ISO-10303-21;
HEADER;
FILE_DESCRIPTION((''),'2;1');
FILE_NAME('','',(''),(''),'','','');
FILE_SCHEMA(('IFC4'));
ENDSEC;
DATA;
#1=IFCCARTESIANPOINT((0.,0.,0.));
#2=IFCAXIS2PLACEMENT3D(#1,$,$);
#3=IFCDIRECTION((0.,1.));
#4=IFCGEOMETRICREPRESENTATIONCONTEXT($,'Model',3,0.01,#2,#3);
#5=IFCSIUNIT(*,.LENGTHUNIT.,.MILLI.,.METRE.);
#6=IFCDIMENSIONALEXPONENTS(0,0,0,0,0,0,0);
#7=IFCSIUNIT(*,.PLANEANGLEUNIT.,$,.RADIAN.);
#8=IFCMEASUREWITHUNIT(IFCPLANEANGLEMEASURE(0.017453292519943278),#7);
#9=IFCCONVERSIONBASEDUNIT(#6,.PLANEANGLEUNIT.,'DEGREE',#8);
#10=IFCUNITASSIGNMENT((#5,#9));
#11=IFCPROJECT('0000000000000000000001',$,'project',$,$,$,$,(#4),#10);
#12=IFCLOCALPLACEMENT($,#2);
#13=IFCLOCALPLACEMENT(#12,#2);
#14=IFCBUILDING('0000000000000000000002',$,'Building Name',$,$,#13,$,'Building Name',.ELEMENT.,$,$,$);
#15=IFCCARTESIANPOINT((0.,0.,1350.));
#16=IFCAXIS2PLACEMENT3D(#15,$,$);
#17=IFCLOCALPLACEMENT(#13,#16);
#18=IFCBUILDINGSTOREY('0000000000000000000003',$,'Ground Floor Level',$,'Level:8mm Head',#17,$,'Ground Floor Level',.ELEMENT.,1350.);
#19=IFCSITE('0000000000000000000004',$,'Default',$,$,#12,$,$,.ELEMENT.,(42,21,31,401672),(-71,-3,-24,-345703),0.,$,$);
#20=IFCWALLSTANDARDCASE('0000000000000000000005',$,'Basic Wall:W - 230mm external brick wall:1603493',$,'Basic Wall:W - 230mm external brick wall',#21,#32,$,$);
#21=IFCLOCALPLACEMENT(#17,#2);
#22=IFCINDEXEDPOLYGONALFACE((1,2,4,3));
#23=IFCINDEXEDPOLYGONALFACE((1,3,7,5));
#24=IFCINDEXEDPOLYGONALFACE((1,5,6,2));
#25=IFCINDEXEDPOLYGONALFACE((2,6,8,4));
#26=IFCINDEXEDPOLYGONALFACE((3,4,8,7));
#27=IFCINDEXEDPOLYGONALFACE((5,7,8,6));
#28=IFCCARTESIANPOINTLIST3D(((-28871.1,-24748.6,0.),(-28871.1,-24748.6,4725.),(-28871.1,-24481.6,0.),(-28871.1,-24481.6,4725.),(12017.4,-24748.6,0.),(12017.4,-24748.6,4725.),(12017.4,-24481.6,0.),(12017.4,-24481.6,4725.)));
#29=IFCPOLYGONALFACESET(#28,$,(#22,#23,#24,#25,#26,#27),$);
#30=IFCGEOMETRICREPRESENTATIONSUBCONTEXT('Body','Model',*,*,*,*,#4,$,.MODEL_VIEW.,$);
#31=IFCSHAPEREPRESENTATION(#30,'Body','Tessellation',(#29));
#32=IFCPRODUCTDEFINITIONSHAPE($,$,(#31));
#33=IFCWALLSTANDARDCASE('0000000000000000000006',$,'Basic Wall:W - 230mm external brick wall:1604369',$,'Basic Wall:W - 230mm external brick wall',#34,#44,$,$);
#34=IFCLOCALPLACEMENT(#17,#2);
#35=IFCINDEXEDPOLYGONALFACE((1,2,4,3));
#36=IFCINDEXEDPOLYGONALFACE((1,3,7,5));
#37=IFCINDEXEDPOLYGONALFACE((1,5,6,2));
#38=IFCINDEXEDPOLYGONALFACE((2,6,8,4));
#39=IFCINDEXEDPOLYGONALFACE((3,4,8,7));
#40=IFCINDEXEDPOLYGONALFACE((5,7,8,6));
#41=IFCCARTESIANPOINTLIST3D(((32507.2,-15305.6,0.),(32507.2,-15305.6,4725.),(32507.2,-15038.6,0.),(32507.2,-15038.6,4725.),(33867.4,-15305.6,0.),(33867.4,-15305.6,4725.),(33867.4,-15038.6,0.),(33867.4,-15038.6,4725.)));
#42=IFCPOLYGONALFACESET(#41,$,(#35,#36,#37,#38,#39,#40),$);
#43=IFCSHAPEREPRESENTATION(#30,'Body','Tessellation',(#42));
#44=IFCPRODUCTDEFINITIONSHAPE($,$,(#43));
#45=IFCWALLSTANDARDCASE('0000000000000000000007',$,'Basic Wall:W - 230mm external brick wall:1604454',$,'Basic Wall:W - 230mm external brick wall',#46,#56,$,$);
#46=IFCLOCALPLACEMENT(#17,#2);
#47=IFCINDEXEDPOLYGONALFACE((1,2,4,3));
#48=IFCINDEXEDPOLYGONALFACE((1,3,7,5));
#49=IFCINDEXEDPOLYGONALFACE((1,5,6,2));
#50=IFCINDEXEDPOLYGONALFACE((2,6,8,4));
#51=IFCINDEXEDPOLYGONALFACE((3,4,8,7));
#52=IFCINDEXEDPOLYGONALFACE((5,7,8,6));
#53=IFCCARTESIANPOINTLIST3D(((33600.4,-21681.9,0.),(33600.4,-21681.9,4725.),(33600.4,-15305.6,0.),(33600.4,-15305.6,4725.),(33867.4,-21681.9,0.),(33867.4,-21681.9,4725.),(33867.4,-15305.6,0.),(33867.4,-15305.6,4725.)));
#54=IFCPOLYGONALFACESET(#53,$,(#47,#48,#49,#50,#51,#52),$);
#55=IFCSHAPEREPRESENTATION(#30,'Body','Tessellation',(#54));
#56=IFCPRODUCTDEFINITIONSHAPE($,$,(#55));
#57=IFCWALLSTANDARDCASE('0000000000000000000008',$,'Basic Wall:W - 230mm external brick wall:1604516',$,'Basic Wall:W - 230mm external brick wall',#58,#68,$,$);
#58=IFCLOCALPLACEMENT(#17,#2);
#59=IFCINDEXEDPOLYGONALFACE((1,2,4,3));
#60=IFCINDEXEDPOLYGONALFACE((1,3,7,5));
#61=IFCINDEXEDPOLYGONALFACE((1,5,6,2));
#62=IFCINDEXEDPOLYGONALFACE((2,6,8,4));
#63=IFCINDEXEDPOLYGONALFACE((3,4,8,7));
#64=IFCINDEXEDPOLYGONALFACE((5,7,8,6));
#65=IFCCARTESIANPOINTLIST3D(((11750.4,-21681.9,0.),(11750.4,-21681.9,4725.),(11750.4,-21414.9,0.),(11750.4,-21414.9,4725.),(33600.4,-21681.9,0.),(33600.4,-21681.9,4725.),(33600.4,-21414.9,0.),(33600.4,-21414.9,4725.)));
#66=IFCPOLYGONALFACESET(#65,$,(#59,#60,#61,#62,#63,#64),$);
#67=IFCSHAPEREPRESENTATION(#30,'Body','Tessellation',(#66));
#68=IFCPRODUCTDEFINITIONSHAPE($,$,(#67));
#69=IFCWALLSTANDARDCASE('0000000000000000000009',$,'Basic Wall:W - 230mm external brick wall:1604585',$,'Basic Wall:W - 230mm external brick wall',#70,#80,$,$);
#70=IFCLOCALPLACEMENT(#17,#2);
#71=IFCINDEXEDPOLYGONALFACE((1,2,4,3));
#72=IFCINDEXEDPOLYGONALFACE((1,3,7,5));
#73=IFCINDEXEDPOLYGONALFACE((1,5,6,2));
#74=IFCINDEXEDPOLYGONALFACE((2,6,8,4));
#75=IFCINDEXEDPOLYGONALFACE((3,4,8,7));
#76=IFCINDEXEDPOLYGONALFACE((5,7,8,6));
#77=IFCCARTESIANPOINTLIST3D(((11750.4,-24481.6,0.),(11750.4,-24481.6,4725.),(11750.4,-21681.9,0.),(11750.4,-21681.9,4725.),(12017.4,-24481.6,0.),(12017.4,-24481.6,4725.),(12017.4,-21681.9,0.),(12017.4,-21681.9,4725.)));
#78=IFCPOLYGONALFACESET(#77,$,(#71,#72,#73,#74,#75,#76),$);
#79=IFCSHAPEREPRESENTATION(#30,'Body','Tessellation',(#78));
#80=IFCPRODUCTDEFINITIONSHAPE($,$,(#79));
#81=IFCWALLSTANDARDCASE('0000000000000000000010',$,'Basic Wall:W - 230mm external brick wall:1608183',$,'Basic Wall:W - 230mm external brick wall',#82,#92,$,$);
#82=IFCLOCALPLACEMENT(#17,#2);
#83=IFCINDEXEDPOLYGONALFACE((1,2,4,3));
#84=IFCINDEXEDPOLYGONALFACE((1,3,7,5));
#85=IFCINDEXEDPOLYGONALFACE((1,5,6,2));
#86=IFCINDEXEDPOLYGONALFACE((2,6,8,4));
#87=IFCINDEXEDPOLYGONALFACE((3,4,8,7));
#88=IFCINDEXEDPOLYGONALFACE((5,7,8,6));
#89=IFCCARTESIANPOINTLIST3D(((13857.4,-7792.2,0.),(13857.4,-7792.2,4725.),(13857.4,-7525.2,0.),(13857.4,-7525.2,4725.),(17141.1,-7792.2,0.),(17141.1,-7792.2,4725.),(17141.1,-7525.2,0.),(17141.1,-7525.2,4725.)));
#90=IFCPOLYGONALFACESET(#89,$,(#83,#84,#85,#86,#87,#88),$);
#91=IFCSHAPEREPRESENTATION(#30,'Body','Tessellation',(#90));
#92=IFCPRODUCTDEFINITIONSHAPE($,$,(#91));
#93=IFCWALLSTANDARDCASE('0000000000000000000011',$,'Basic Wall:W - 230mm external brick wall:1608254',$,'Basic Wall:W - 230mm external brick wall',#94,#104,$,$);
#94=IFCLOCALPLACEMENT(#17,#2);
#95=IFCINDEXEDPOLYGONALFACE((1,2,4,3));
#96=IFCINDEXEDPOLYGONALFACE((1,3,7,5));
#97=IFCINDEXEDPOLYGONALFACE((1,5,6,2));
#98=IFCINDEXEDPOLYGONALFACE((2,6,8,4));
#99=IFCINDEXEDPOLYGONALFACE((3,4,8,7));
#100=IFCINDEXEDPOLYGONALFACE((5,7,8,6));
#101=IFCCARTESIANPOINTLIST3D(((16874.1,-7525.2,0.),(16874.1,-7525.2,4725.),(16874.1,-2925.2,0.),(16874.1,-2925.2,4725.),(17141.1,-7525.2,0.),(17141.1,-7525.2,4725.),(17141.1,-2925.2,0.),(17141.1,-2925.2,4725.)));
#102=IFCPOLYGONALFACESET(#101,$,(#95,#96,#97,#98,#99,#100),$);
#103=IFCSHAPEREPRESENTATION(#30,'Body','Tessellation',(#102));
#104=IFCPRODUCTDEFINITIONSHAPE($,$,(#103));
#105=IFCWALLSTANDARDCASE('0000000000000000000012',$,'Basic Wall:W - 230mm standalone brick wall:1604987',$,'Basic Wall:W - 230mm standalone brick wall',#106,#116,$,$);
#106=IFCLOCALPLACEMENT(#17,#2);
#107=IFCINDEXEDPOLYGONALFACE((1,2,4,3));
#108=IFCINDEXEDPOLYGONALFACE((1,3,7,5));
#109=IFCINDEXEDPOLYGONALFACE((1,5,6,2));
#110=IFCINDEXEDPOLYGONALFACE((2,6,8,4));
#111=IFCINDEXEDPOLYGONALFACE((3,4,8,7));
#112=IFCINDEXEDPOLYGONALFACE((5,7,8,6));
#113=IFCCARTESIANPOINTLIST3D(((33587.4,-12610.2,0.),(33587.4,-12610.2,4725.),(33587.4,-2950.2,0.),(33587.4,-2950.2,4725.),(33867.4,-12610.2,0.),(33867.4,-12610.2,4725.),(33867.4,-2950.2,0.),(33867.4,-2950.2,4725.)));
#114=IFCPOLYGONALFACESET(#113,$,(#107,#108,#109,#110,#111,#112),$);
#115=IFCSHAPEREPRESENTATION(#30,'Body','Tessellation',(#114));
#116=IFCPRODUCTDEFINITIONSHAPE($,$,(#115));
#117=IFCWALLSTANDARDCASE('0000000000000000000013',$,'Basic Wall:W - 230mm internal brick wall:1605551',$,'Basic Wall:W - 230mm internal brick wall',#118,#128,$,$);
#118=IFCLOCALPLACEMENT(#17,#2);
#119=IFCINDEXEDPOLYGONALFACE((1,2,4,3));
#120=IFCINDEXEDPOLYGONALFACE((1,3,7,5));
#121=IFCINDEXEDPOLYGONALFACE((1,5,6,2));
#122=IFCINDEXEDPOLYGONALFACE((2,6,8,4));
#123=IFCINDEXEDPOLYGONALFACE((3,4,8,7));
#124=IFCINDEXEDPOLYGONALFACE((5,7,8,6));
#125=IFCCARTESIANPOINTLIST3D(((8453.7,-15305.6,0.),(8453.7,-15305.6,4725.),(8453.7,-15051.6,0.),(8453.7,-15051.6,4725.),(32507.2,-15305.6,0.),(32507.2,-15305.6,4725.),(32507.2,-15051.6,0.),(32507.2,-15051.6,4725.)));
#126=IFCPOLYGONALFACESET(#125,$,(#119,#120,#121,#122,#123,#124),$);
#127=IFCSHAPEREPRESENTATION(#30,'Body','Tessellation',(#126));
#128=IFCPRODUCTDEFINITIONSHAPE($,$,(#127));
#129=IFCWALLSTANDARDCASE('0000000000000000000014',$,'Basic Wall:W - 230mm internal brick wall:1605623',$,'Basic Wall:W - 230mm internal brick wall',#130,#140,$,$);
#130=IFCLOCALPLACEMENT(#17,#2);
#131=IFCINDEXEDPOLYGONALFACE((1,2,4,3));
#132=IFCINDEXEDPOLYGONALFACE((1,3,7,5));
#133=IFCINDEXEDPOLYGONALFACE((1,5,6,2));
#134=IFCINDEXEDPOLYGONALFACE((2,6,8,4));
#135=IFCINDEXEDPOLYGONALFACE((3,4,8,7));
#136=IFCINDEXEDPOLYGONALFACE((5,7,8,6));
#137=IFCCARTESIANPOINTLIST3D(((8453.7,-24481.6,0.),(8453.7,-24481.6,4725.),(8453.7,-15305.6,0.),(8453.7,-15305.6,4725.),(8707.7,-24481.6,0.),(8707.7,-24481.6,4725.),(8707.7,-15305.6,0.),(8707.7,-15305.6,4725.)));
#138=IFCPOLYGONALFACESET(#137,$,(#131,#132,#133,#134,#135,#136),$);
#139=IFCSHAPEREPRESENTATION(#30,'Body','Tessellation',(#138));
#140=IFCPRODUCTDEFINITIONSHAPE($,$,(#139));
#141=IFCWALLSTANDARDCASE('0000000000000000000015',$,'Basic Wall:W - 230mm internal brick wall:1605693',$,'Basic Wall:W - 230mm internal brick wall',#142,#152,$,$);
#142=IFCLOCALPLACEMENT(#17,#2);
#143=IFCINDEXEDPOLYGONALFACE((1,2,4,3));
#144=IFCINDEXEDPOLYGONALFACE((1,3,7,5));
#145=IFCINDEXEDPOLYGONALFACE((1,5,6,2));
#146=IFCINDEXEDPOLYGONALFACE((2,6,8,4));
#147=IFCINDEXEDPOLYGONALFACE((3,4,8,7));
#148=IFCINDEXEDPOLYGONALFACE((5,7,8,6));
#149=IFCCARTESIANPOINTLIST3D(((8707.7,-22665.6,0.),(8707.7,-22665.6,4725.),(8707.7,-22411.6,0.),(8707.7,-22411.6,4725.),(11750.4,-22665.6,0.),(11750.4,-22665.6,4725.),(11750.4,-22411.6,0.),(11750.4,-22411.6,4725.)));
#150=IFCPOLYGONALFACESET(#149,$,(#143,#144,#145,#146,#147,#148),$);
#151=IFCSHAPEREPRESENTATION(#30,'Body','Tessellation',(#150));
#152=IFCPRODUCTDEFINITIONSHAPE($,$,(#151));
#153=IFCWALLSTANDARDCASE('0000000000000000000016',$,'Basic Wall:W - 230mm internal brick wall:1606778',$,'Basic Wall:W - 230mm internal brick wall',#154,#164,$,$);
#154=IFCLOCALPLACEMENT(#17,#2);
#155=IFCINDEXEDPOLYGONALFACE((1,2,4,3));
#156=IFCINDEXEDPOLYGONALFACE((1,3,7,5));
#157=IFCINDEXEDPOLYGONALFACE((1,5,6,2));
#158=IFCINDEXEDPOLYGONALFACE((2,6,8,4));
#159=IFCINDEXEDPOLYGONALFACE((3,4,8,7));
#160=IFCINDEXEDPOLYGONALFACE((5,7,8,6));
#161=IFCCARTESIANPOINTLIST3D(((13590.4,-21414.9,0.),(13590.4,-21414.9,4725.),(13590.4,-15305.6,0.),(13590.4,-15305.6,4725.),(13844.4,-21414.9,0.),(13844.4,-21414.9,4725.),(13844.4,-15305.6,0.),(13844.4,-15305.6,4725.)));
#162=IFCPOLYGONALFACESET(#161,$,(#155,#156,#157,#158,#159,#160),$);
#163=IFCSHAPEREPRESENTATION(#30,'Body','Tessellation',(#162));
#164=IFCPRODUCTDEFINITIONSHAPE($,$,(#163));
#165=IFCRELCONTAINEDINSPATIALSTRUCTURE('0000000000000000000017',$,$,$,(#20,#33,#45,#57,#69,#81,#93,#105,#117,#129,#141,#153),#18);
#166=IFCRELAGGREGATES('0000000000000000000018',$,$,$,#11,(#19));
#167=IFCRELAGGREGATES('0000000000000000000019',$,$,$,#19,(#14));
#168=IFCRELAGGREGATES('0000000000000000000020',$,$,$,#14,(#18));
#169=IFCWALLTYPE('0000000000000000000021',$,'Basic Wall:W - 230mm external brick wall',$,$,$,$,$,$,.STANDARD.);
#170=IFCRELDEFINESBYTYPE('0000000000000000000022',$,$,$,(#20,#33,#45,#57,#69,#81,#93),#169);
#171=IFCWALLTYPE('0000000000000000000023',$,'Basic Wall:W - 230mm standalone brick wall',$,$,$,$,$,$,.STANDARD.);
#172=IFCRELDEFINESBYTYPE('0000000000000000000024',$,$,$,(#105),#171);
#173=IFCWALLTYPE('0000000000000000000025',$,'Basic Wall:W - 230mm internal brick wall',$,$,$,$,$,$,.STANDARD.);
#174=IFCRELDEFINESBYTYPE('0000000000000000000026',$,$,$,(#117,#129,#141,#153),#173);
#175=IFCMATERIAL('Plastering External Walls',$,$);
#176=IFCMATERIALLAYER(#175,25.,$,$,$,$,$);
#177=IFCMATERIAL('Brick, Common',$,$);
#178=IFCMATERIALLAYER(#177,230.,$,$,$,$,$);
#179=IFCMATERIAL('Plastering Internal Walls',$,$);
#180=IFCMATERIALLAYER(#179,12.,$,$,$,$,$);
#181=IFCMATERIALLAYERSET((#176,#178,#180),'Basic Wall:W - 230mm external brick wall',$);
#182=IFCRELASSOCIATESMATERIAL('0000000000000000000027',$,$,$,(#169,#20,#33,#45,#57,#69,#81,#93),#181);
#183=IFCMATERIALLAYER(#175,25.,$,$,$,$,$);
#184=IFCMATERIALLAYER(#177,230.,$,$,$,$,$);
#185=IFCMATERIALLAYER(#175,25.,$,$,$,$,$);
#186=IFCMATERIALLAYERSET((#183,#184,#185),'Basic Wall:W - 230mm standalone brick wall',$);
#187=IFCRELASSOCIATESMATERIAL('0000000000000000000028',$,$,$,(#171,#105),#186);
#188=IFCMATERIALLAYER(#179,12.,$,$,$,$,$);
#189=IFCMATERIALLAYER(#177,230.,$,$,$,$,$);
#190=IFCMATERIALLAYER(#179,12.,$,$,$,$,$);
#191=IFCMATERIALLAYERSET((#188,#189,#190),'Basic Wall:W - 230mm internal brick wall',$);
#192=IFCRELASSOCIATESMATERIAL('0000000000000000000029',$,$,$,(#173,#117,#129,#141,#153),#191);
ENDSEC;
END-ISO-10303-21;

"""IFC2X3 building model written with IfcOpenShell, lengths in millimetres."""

from ifc_helpers import new_model, entity, si_unit, converted_unit, direction, frame, frame_2d, origin, place, context, subcontext, project, spatial, rectangle, extrude, material, layer, layer_set, layer_usage, type_object, element, save


model = new_model("IFC2X3")

# Units and contexts
model_context = context("Model", 3, precision=0.01, world=origin(), true_north=direction((0.0, 1.0)))
body_context = subcontext(model_context, "Body", "Model", "MODEL_VIEW")
ifc_project = project(units=[si_unit("LENGTHUNIT", "METRE", prefix="MILLI"), converted_unit("PLANEANGLEUNIT", "DEGREE", entity("IfcPlaneAngleMeasure", 0.017453292519943278), si_unit("PLANEANGLEUNIT", "RADIAN"), dimensions=[0, 0, 0, 0, 0, 0, 0])], contexts=[model_context])

# Site, building, storey
site_placement = place(None, origin())
site = spatial("IfcSite", under=ifc_project, at=site_placement, Name="Default", CompositionType="ELEMENT", RefLatitude=(42, 21, 31, 401672), RefLongitude=(-71, -3, -24, -345703), RefElevation=0.0)
building_placement = place(site_placement, origin())
building = spatial("IfcBuilding", under=site, at=building_placement, Name="Building Name", LongName="Building Name", CompositionType="ELEMENT")
storey_placement = place(building_placement, frame((0.0, 0.0, 1350.0)))
storey = spatial("IfcBuildingStorey", under=building, at=storey_placement, Name="Ground Floor Level", ObjectType="Level:8mm Head", LongName="Ground Floor Level", CompositionType="ELEMENT", Elevation=1350.0)

# Walls
ifc_material_1 = material(Name="Plastering External Walls")
ifc_layer_1 = layer(ifc_material_1, 25.0)
ifc_material_2 = material(Name="Brick, Common")
ifc_layer_2 = layer(ifc_material_2, 230.0)
ifc_material_3 = material(Name="Plastering Internal Walls")
ifc_layer_3 = layer(ifc_material_3, 12.0)
ifc_layer_set_1 = layer_set([ifc_layer_1, ifc_layer_2, ifc_layer_3], Name="Basic Wall:W - 230mm external brick wall")
ifc_layer_usage_1 = layer_usage(ifc_layer_set_1, "AXIS2", "NEGATIVE", 133.5)
wall_type_1 = type_object("IfcWallType", Name="Basic Wall:W - 230mm external brick wall", PredefinedType="STANDARD", material=ifc_layer_set_1)
wall_1_placement = place(storey_placement, frame((12017.4, -24615.1, 0.0), z_axis=(0.0, 0.0, 1.0), x_axis=(-1.0, 0.0, 0.0)))
element("IfcWallStandardCase", 1, at=wall_1_placement, inside=storey, type_object=wall_type_1, material=ifc_layer_usage_1, Name="Basic Wall:W - 230mm external brick wall:1603493", ObjectType="Basic Wall:W - 230mm external brick wall", context=body_context, shape_type="SweptSolid", body=[
    extrude(rectangle(XDim=40888.5, YDim=267.0, at=frame_2d((20444.2, 0.0), x_axis=(-1.0, 0.0))), origin(), (0.0, 0.0, 1.0), 4725.0),
])
ifc_layer_usage_2 = layer_usage(ifc_layer_set_1, "AXIS2", "NEGATIVE", 133.5)
wall_2_placement = place(storey_placement, frame((32507.2, -15172.1, 0.0)))
element("IfcWallStandardCase", 2, at=wall_2_placement, inside=storey, type_object=wall_type_1, material=ifc_layer_usage_2, Name="Basic Wall:W - 230mm external brick wall:1604369", ObjectType="Basic Wall:W - 230mm external brick wall", context=body_context, shape_type="SweptSolid", body=[
    extrude(rectangle(XDim=1360.2, YDim=267.0, at=frame_2d((680.1, 0.0), x_axis=(-1.0, 0.0))), origin(), (0.0, 0.0, 1.0), 4725.0),
])
ifc_layer_usage_3 = layer_usage(ifc_layer_set_1, "AXIS2", "NEGATIVE", 133.5)
wall_3_placement = place(storey_placement, frame((33733.9, -15305.6, 0.0), z_axis=(0.0, 0.0, 1.0), x_axis=(0.0, -1.0, 0.0)))
element("IfcWallStandardCase", 3, at=wall_3_placement, inside=storey, type_object=wall_type_1, material=ifc_layer_usage_3, Name="Basic Wall:W - 230mm external brick wall:1604454", ObjectType="Basic Wall:W - 230mm external brick wall", context=body_context, shape_type="SweptSolid", body=[
    extrude(rectangle(XDim=6376.3, YDim=267.0, at=frame_2d((3188.2, 0.0), x_axis=(-1.0, 0.0))), origin(), (0.0, 0.0, 1.0), 4725.0),
])
ifc_layer_usage_4 = layer_usage(ifc_layer_set_1, "AXIS2", "NEGATIVE", 133.5)
wall_4_placement = place(storey_placement, frame((33600.4, -21548.4, 0.0), z_axis=(0.0, 0.0, 1.0), x_axis=(-1.0, 0.0, 0.0)))
element("IfcWallStandardCase", 4, at=wall_4_placement, inside=storey, type_object=wall_type_1, material=ifc_layer_usage_4, Name="Basic Wall:W - 230mm external brick wall:1604516", ObjectType="Basic Wall:W - 230mm external brick wall", context=body_context, shape_type="SweptSolid", body=[
    extrude(rectangle(XDim=21850.0, YDim=267.0, at=frame_2d((10925.0, 0.0), x_axis=(-1.0, 0.0))), origin(), (0.0, 0.0, 1.0), 4725.0),
])
ifc_layer_usage_5 = layer_usage(ifc_layer_set_1, "AXIS2", "NEGATIVE", 133.5)
wall_5_placement = place(storey_placement, frame((11883.9, -21681.9, 0.0), z_axis=(0.0, 0.0, 1.0), x_axis=(0.0, -1.0, 0.0)))
element("IfcWallStandardCase", 5, at=wall_5_placement, inside=storey, type_object=wall_type_1, material=ifc_layer_usage_5, Name="Basic Wall:W - 230mm external brick wall:1604585", ObjectType="Basic Wall:W - 230mm external brick wall", context=body_context, shape_type="SweptSolid", body=[
    extrude(rectangle(XDim=2799.7, YDim=267.0, at=frame_2d((1399.8, 0.0), x_axis=(-1.0, 0.0))), origin(), (0.0, 0.0, 1.0), 4725.0),
])
ifc_layer_usage_6 = layer_usage(ifc_layer_set_1, "AXIS2", "NEGATIVE", 133.5)
wall_6_placement = place(storey_placement, frame((13857.4, -7658.7, 0.0)))
element("IfcWallStandardCase", 6, at=wall_6_placement, inside=storey, type_object=wall_type_1, material=ifc_layer_usage_6, Name="Basic Wall:W - 230mm external brick wall:1608183", ObjectType="Basic Wall:W - 230mm external brick wall", context=body_context, shape_type="SweptSolid", body=[
    extrude(rectangle(XDim=3283.7, YDim=267.0, at=frame_2d((1641.8, 0.0), x_axis=(-1.0, 0.0))), origin(), (0.0, 0.0, 1.0), 4725.0),
])
ifc_layer_usage_7 = layer_usage(ifc_layer_set_1, "AXIS2", "NEGATIVE", 133.5)
wall_7_placement = place(storey_placement, frame((17007.6, -7525.2, 0.0), z_axis=(0.0, 0.0, 1.0), x_axis=(0.0, 1.0, 0.0)))
element("IfcWallStandardCase", 7, at=wall_7_placement, inside=storey, type_object=wall_type_1, material=ifc_layer_usage_7, Name="Basic Wall:W - 230mm external brick wall:1608254", ObjectType="Basic Wall:W - 230mm external brick wall", context=body_context, shape_type="SweptSolid", body=[
    extrude(rectangle(XDim=4600.0, YDim=267.0, at=frame_2d((2300.0, 0.0), x_axis=(-1.0, 0.0))), origin(), (0.0, 0.0, 1.0), 4725.0),
])
ifc_layer_4 = layer(ifc_material_1, 25.0)
ifc_layer_5 = layer(ifc_material_2, 230.0)
ifc_layer_6 = layer(ifc_material_1, 25.0)
ifc_layer_set_2 = layer_set([ifc_layer_4, ifc_layer_5, ifc_layer_6], Name="Basic Wall:W - 230mm standalone brick wall")
ifc_layer_usage_8 = layer_usage(ifc_layer_set_2, "AXIS2", "NEGATIVE", 140.0)
wall_type_2 = type_object("IfcWallType", Name="Basic Wall:W - 230mm standalone brick wall", PredefinedType="STANDARD", material=ifc_layer_set_2)
wall_8_placement = place(storey_placement, frame((33727.4, -12610.2, 0.0), z_axis=(0.0, 0.0, 1.0), x_axis=(0.0, 1.0, 0.0)))
element("IfcWallStandardCase", 8, at=wall_8_placement, inside=storey, type_object=wall_type_2, material=ifc_layer_usage_8, Name="Basic Wall:W - 230mm standalone brick wall:1604987", ObjectType="Basic Wall:W - 230mm standalone brick wall", context=body_context, shape_type="SweptSolid", body=[
    extrude(rectangle(XDim=9660.0, YDim=280.0, at=frame_2d((4830.0, 0.0), x_axis=(-1.0, 0.0))), origin(), (0.0, 0.0, 1.0), 4725.0),
])
ifc_layer_7 = layer(ifc_material_3, 12.0)
ifc_layer_8 = layer(ifc_material_2, 230.0)
ifc_layer_9 = layer(ifc_material_3, 12.0)
ifc_layer_set_3 = layer_set([ifc_layer_7, ifc_layer_8, ifc_layer_9], Name="Basic Wall:W - 230mm internal brick wall")
ifc_layer_usage_9 = layer_usage(ifc_layer_set_3, "AXIS2", "NEGATIVE", 127.0)
wall_type_3 = type_object("IfcWallType", Name="Basic Wall:W - 230mm internal brick wall", PredefinedType="STANDARD", material=ifc_layer_set_3)
wall_9_placement = place(storey_placement, frame((32507.2, -15178.6, 0.0), z_axis=(0.0, 0.0, 1.0), x_axis=(-1.0, 0.0, 0.0)))
element("IfcWallStandardCase", 9, at=wall_9_placement, inside=storey, type_object=wall_type_3, material=ifc_layer_usage_9, Name="Basic Wall:W - 230mm internal brick wall:1605551", ObjectType="Basic Wall:W - 230mm internal brick wall", context=body_context, shape_type="SweptSolid", body=[
    extrude(rectangle(XDim=24053.5, YDim=254.0, at=frame_2d((12026.7, 0.0), x_axis=(-1.0, 0.0))), origin(), (0.0, 0.0, 1.0), 4725.0),
])
ifc_layer_usage_10 = layer_usage(ifc_layer_set_3, "AXIS2", "NEGATIVE", 127.0)
wall_10_placement = place(storey_placement, frame((8580.7, -15305.6, 0.0), z_axis=(0.0, 0.0, 1.0), x_axis=(0.0, -1.0, 0.0)))
element("IfcWallStandardCase", 10, at=wall_10_placement, inside=storey, type_object=wall_type_3, material=ifc_layer_usage_10, Name="Basic Wall:W - 230mm internal brick wall:1605623", ObjectType="Basic Wall:W - 230mm internal brick wall", context=body_context, shape_type="SweptSolid", body=[
    extrude(rectangle(XDim=9176.0, YDim=254.0, at=frame_2d((4588.0, 0.0), x_axis=(-1.0, 0.0))), origin(), (0.0, 0.0, 1.0), 4725.0),
])
ifc_layer_usage_11 = layer_usage(ifc_layer_set_3, "AXIS2", "NEGATIVE", 127.0)
wall_11_placement = place(storey_placement, frame((11750.4, -22538.6, 0.0), z_axis=(0.0, 0.0, 1.0), x_axis=(-1.0, 0.0, 0.0)))
element("IfcWallStandardCase", 11, at=wall_11_placement, inside=storey, type_object=wall_type_3, material=ifc_layer_usage_11, Name="Basic Wall:W - 230mm internal brick wall:1605693", ObjectType="Basic Wall:W - 230mm internal brick wall", context=body_context, shape_type="SweptSolid", body=[
    extrude(rectangle(XDim=3042.7, YDim=254.0, at=frame_2d((1521.3, 0.0), x_axis=(-1.0, 0.0))), origin(), (0.0, 0.0, 1.0), 4725.0),
])
ifc_layer_usage_12 = layer_usage(ifc_layer_set_3, "AXIS2", "NEGATIVE", 127.0)
wall_12_placement = place(storey_placement, frame((13717.4, -21414.9, 0.0), z_axis=(0.0, 0.0, 1.0), x_axis=(0.0, 1.0, 0.0)))
element("IfcWallStandardCase", 12, at=wall_12_placement, inside=storey, type_object=wall_type_3, material=ifc_layer_usage_12, Name="Basic Wall:W - 230mm internal brick wall:1606778", ObjectType="Basic Wall:W - 230mm internal brick wall", context=body_context, shape_type="SweptSolid", body=[
    extrude(rectangle(XDim=6109.3, YDim=254.0, at=frame_2d((3054.7, 0.0), x_axis=(-1.0, 0.0))), origin(), (0.0, 0.0, 1.0), 4725.0),
])

save(model, "model.ifc")
